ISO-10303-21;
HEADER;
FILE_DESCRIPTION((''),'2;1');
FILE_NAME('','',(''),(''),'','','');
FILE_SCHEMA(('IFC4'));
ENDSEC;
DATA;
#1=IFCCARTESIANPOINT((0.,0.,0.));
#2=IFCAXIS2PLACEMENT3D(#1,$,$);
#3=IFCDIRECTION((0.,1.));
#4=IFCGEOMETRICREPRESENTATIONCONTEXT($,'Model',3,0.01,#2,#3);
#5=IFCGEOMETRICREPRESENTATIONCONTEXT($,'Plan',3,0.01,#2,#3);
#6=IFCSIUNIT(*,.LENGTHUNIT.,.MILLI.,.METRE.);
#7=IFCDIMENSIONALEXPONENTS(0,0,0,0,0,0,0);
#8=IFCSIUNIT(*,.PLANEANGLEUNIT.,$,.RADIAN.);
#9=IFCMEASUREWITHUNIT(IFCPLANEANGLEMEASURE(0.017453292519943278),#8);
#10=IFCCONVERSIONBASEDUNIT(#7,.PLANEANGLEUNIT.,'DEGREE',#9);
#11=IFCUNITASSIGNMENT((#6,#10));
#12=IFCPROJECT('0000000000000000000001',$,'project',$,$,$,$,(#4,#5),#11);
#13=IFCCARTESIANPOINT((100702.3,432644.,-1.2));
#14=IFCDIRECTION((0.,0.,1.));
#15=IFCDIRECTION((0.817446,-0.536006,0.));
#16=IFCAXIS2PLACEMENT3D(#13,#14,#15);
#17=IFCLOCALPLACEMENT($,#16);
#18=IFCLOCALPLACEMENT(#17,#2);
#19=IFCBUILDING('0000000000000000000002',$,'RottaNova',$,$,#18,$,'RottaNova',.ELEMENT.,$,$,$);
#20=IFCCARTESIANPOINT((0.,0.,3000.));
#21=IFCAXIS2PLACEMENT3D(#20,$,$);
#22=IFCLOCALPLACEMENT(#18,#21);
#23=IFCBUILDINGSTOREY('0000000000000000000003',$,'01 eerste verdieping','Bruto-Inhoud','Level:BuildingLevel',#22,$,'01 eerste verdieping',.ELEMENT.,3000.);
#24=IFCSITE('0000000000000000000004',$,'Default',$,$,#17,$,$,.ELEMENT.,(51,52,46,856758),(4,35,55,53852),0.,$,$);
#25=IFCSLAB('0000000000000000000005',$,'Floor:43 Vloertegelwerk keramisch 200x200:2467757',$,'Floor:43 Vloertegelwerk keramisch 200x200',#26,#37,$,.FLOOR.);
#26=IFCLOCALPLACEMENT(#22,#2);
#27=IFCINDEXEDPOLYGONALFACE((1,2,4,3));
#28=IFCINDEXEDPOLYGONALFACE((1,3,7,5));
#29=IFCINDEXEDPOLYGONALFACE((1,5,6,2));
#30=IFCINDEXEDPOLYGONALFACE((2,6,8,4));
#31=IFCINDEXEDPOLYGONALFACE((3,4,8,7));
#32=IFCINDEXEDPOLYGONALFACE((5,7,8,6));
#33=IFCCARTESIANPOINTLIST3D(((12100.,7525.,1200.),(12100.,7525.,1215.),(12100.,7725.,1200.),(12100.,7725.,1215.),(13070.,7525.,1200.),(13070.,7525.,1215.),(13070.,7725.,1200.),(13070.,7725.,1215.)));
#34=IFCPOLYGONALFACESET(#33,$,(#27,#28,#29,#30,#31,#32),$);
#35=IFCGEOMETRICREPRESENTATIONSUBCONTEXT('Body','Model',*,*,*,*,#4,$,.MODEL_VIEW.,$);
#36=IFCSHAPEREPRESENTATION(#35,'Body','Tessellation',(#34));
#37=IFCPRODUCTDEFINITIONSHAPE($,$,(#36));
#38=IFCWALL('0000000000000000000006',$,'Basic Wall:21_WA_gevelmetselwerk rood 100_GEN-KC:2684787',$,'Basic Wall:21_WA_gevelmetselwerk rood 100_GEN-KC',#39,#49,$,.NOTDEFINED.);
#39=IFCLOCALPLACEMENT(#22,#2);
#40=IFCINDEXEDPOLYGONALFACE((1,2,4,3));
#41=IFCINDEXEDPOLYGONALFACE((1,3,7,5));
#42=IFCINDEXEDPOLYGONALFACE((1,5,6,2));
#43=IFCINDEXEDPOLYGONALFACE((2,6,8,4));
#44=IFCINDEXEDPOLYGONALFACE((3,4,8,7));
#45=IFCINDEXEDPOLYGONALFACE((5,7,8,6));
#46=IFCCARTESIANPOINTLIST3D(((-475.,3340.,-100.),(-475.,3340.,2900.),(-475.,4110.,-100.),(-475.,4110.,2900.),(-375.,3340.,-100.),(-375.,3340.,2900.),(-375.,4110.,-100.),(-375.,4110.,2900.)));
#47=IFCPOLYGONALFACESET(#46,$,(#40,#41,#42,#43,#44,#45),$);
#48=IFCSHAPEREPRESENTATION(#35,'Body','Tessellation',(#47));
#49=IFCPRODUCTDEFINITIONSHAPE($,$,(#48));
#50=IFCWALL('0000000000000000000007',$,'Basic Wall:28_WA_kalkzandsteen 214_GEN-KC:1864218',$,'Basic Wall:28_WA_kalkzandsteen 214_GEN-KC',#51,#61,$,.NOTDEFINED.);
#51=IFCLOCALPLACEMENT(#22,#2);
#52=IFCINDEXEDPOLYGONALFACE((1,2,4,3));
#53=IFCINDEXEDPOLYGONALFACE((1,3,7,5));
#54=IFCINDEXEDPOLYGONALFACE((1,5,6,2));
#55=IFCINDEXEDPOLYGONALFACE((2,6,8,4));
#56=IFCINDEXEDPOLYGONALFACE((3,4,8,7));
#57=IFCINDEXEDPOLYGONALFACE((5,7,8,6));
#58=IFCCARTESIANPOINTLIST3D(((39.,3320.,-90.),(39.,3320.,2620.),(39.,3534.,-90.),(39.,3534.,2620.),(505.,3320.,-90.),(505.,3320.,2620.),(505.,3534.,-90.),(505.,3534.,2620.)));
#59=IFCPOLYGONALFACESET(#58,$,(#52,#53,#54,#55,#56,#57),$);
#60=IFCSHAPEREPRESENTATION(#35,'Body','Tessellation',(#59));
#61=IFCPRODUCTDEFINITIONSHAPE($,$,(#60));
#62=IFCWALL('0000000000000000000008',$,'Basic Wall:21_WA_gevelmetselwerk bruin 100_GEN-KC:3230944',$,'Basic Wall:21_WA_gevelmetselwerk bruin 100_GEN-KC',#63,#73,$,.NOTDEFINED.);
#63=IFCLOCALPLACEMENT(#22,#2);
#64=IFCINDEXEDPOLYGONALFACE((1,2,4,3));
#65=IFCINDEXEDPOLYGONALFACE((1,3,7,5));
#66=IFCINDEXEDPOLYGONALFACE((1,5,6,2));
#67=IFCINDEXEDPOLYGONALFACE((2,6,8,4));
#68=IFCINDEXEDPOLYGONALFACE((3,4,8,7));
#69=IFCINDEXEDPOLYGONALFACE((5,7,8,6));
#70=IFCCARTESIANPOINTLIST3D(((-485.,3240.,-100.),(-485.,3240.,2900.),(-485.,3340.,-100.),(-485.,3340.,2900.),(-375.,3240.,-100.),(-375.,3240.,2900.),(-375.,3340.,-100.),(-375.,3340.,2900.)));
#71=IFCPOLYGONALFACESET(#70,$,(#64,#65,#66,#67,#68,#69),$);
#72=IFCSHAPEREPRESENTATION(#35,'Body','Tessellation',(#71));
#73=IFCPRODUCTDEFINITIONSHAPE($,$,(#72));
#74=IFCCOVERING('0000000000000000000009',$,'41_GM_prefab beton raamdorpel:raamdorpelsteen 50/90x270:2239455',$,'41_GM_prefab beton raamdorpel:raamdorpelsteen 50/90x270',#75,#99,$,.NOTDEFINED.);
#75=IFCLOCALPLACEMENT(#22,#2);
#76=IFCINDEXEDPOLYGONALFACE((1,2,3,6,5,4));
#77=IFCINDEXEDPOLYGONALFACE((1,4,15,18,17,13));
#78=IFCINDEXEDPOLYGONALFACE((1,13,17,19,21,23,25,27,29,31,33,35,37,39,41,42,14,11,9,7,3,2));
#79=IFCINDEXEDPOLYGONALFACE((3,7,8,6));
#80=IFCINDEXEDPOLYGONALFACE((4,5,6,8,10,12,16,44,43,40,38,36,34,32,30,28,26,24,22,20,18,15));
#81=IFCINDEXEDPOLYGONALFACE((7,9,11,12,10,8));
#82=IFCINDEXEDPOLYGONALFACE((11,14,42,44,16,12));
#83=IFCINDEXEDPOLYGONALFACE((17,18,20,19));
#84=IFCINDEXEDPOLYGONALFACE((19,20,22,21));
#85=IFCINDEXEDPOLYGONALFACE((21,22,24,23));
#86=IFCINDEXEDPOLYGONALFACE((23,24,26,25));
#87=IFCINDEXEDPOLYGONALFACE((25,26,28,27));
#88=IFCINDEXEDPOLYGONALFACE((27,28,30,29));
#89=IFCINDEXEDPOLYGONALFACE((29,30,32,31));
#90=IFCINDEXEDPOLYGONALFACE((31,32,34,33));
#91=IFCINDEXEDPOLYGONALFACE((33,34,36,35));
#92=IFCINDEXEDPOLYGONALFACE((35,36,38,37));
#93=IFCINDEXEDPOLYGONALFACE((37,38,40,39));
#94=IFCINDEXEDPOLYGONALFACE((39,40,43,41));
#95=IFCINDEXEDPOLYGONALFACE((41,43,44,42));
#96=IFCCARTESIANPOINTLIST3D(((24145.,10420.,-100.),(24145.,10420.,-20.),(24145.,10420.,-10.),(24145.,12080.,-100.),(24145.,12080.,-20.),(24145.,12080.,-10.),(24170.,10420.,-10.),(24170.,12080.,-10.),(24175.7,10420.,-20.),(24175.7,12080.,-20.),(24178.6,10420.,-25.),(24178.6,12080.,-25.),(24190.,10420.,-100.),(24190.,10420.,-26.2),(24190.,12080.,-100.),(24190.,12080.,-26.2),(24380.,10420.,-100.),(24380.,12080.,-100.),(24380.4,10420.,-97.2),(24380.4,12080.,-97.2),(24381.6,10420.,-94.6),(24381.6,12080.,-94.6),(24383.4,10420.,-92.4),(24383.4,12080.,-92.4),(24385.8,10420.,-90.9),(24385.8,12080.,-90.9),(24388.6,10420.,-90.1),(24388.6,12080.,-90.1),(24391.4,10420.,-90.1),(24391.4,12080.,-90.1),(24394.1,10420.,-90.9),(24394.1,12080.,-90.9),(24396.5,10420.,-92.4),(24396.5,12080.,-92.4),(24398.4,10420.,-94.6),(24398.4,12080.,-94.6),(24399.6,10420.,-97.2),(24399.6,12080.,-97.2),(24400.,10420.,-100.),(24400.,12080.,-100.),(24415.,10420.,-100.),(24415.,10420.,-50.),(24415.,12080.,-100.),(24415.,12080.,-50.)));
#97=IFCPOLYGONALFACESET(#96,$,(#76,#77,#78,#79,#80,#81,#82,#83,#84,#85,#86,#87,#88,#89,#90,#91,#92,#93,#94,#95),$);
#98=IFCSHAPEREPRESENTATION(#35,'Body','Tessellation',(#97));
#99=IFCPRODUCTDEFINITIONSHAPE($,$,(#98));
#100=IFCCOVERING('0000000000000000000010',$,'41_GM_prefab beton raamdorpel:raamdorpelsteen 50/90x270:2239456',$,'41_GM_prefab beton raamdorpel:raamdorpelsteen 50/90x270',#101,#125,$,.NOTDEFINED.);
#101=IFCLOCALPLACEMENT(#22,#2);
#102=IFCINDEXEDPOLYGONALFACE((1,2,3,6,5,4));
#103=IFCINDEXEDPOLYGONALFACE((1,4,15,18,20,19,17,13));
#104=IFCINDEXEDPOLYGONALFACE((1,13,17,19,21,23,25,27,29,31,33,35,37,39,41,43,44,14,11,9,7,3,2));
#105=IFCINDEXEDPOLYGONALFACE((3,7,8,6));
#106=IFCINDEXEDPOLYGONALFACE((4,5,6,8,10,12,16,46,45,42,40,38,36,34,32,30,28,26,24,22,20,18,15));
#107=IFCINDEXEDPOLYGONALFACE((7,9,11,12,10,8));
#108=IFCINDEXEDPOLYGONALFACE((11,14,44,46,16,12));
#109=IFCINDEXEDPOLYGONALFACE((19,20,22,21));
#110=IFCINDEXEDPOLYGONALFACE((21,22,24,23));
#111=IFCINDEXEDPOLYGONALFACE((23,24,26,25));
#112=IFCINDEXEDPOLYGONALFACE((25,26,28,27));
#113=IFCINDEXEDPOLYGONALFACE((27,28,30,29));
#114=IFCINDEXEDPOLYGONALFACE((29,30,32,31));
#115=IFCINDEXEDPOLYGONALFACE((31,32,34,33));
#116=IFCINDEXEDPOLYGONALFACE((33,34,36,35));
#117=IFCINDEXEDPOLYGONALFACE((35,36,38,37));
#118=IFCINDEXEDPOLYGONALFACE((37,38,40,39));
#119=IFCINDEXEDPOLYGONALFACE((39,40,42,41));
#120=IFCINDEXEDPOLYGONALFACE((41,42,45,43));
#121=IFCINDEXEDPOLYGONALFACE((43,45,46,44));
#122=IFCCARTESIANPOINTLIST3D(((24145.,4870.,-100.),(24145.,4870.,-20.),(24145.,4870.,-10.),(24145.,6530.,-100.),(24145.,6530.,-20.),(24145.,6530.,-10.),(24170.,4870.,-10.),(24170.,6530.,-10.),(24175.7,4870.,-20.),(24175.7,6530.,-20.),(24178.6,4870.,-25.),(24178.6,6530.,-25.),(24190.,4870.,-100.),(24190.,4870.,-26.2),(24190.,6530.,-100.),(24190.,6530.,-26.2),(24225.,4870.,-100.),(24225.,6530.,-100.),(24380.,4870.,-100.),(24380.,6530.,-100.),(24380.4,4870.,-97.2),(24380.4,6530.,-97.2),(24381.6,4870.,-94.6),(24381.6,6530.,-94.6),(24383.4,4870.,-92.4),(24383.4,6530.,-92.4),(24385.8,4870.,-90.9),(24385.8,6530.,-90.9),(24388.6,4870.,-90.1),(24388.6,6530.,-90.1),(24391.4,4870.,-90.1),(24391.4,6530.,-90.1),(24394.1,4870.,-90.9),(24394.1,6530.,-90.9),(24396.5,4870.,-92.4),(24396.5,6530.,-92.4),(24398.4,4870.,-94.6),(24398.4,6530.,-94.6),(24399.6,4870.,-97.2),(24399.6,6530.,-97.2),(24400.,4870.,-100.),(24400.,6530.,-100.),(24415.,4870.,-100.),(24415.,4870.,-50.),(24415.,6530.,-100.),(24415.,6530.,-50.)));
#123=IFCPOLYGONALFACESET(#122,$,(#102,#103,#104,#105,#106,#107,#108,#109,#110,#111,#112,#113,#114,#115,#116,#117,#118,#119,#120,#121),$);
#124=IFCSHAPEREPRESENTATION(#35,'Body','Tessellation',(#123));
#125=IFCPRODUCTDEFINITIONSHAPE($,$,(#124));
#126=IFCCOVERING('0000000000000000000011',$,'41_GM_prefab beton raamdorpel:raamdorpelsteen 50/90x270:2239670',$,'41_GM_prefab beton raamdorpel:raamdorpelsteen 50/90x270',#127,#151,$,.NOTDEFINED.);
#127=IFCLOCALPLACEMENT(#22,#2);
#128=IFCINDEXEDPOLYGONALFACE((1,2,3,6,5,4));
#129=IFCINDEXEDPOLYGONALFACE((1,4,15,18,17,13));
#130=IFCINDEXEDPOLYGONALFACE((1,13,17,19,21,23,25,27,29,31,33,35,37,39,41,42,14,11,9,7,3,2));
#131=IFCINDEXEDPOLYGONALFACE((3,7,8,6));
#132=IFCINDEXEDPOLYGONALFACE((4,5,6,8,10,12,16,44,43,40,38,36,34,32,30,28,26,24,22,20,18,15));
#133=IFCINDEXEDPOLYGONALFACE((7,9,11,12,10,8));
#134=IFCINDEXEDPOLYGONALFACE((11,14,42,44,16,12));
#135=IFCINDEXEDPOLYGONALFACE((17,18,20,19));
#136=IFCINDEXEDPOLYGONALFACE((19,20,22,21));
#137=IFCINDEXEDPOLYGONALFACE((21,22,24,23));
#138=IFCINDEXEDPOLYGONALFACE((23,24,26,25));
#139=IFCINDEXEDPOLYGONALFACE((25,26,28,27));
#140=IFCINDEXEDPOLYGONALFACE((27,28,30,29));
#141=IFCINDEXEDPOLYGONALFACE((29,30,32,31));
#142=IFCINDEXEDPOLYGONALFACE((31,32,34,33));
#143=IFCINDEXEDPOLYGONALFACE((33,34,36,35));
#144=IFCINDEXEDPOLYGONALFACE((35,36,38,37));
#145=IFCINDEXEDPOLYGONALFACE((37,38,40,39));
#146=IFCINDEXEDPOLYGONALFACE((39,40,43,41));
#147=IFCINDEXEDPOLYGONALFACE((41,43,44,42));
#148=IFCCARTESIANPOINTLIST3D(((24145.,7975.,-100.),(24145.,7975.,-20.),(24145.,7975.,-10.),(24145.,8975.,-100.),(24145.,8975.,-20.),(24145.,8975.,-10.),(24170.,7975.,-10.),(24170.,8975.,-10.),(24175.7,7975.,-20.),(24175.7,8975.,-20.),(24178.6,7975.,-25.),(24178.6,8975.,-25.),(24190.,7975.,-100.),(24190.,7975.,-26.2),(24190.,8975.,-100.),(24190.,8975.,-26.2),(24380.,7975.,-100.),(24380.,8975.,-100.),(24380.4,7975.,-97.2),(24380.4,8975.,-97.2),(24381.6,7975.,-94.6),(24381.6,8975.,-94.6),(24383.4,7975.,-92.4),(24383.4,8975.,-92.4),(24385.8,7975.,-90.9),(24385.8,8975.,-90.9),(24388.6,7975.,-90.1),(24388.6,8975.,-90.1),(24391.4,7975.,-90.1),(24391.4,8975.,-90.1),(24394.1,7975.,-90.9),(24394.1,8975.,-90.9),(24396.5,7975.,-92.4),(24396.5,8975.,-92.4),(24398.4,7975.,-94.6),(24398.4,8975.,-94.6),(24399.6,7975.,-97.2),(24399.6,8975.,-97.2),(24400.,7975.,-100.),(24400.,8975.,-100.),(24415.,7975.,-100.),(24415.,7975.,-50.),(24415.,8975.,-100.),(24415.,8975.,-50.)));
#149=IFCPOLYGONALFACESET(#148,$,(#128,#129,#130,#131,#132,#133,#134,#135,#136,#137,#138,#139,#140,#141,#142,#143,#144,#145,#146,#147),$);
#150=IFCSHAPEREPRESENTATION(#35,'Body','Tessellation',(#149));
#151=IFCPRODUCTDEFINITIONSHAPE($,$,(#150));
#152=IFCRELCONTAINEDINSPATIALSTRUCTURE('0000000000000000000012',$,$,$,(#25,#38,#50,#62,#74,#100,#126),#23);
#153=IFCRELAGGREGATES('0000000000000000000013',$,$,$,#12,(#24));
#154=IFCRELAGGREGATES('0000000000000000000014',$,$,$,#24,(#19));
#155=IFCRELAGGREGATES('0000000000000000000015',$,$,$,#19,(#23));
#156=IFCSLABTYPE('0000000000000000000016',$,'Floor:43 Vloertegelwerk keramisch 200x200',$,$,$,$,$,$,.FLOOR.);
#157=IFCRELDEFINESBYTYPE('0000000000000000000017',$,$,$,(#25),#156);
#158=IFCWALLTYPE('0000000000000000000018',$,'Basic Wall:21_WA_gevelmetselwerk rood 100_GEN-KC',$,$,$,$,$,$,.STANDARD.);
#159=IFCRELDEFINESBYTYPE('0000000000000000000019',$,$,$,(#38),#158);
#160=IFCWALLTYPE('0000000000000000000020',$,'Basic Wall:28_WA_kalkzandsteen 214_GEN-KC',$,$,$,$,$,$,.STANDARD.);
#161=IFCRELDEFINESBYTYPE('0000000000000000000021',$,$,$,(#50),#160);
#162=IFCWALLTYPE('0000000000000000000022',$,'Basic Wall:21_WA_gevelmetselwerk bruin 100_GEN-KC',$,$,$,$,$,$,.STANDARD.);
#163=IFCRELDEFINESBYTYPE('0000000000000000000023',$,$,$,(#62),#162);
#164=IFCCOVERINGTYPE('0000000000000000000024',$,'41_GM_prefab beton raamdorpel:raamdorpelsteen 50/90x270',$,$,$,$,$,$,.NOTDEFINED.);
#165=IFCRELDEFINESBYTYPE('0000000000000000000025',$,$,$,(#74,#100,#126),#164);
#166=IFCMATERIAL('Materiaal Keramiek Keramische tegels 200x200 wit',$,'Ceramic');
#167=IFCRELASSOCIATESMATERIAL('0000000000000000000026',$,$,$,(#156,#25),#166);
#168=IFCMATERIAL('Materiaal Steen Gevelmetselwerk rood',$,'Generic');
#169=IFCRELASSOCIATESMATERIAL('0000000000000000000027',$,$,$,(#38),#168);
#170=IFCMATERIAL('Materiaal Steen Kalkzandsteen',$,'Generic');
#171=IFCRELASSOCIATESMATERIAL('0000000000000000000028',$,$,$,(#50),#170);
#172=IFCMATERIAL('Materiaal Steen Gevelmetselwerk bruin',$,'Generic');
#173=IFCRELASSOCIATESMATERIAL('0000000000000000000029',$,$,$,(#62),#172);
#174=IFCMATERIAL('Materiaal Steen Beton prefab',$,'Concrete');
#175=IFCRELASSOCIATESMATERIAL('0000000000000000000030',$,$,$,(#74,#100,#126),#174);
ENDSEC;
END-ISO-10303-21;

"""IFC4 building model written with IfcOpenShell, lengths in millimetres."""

from ifc_helpers import new_model, entity, si_unit, converted_unit, direction, frame, origin, place, context, subcontext, project, spatial, line, arc, indexed_curve, outline, extrude, material, type_object, element, save


model = new_model("IFC4")

# Units and contexts
model_context = context("Model", 3, precision=0.01, world=origin(), true_north=direction((0.0, 1.0)))
plan_context = context("Plan", 3, precision=0.01, world=origin(), true_north=direction((0.0, 1.0)))
body_context = subcontext(model_context, "Body", "Model", "MODEL_VIEW")
ifc_project = project(units=[si_unit("LENGTHUNIT", "METRE", prefix="MILLI"), converted_unit("PLANEANGLEUNIT", "DEGREE", entity("IfcPlaneAngleMeasure", 0.017453292519943278), si_unit("PLANEANGLEUNIT", "RADIAN"), dimensions=[0, 0, 0, 0, 0, 0, 0])], contexts=[model_context, plan_context])

# Site, building, storey
site_placement = place(None, frame((100702.3, 432644.0, -1.2), z_axis=(0.0, 0.0, 1.0), x_axis=(0.817446, -0.536006, 0.0)))
site = spatial("IfcSite", under=ifc_project, at=site_placement, Name="Default", CompositionType="ELEMENT", RefLatitude=(51, 52, 46, 856758), RefLongitude=(4, 35, 55, 53852), RefElevation=0.0)
building_placement = place(site_placement, origin())
building = spatial("IfcBuilding", under=site, at=building_placement, Name="RottaNova", LongName="RottaNova", CompositionType="ELEMENT")
storey_placement = place(building_placement, frame((0.0, 0.0, 3000.0)))
storey = spatial("IfcBuildingStorey", under=building, at=storey_placement, Name="01 eerste verdieping", Description="Bruto-Inhoud", ObjectType="Level:BuildingLevel", LongName="01 eerste verdieping", CompositionType="ELEMENT", Elevation=3000.0)

# Shared definitions
ifc_material_1 = material(Name="Materiaal Steen Beton prefab", Category="Concrete")

# Slab
ifc_material_2 = material(Name="Materiaal Keramiek Keramische tegels 200x200 wit", Category="Ceramic")
slab_type = type_object("IfcSlabType", Name="Floor:43 Vloertegelwerk keramisch 200x200", PredefinedType="FLOOR", material=ifc_material_2)
slab_placement = place(storey_placement, origin())
element("IfcSlab", 1, at=slab_placement, inside=storey, type_object=slab_type, material=ifc_material_2, Name="Floor:43 Vloertegelwerk keramisch 200x200:2467757", ObjectType="Floor:43 Vloertegelwerk keramisch 200x200", PredefinedType="FLOOR", context=body_context, shape_type="SweptSolid", body=[
    extrude(outline(indexed_curve([(-100.0, -485.0), (100.0, -485.0), (100.0, 485.0), (-100.0, 485.0), (-100.0, -485.0)], self_intersect=False)), frame((12585.0, 7625.0, 1215.0), z_axis=(0.0, 0.0, -1.0), x_axis=(0.0, 1.0, 0.0)), (0.0, 0.0, 1.0), 15.0),
])

# Walls
ifc_material_3 = material(Name="Materiaal Steen Gevelmetselwerk rood", Category="Generic")
wall_type_1 = type_object("IfcWallType", Name="Basic Wall:21_WA_gevelmetselwerk rood 100_GEN-KC", PredefinedType="STANDARD")
wall_1_placement = place(storey_placement, frame((-425.0, 3340.0, -100.0), z_axis=(0.0, 0.0, 1.0), x_axis=(0.0, 1.0, 0.0)))
element("IfcWall", 2, at=wall_1_placement, inside=storey, type_object=wall_type_1, material=ifc_material_3, Name="Basic Wall:21_WA_gevelmetselwerk rood 100_GEN-KC:2684787", ObjectType="Basic Wall:21_WA_gevelmetselwerk rood 100_GEN-KC", PredefinedType="NOTDEFINED", context=body_context, shape_type="SweptSolid", body=[
    extrude(outline(indexed_curve([(770.0, 50.0), (0.0, 50.0), (0.0, -50.0), (770.0, -50.0), (770.0, 50.0)], self_intersect=False)), origin(), (0.0, 0.0, 1.0), 3000.0),
])
ifc_material_4 = material(Name="Materiaal Steen Kalkzandsteen", Category="Generic")
wall_type_2 = type_object("IfcWallType", Name="Basic Wall:28_WA_kalkzandsteen 214_GEN-KC", PredefinedType="STANDARD")
wall_2_placement = place(storey_placement, frame((39.0, 3427.0, -90.0)))
element("IfcWall", 3, at=wall_2_placement, inside=storey, type_object=wall_type_2, material=ifc_material_4, Name="Basic Wall:28_WA_kalkzandsteen 214_GEN-KC:1864218", ObjectType="Basic Wall:28_WA_kalkzandsteen 214_GEN-KC", PredefinedType="NOTDEFINED", context=body_context, shape_type="SweptSolid", body=[
    extrude(outline(indexed_curve([(466.0, 107.0), (0.0, 107.0), (0.0, -107.0), (466.0, -107.0), (466.0, 107.0)], self_intersect=False)), origin(), (0.0, 0.0, 1.0), 2710.0),
])
ifc_material_5 = material(Name="Materiaal Steen Gevelmetselwerk bruin", Category="Generic")
wall_type_3 = type_object("IfcWallType", Name="Basic Wall:21_WA_gevelmetselwerk bruin 100_GEN-KC", PredefinedType="STANDARD")
wall_3_placement = place(storey_placement, frame((-485.0, 3290.0, -100.0)))
element("IfcWall", 4, at=wall_3_placement, inside=storey, type_object=wall_type_3, material=ifc_material_5, Name="Basic Wall:21_WA_gevelmetselwerk bruin 100_GEN-KC:3230944", ObjectType="Basic Wall:21_WA_gevelmetselwerk bruin 100_GEN-KC", PredefinedType="NOTDEFINED", context=body_context, shape_type="SweptSolid", body=[
    extrude(outline(indexed_curve([(110.0, 50.0), (0.0, 50.0), (0.0, -50.0), (110.0, -50.0), (110.0, 50.0)], self_intersect=False)), origin(), (0.0, 0.0, 1.0), 3000.0),
])

# Coverings
covering_type_1 = type_object("IfcCoveringType", Name="41_GM_prefab beton raamdorpel:raamdorpelsteen 50/90x270", PredefinedType="NOTDEFINED")
covering_1_placement = place(storey_placement, origin())
element("IfcCovering", 5, at=covering_1_placement, inside=storey, type_object=covering_type_1, material=ifc_material_1, Name="41_GM_prefab beton raamdorpel:raamdorpelsteen 50/90x270:2239455", ObjectType="41_GM_prefab beton raamdorpel:raamdorpelsteen 50/90x270", PredefinedType="NOTDEFINED", context=body_context, shape_type="SweptSolid", body=[
    extrude(outline(indexed_curve([(-77.0, -43.1), (-89.5, -64.7), (-80.8, -69.7), (-11.5, -109.7), (11.0, -70.7), (106.0, 93.8), (102.3, 107.5), (116.0, 111.1), (123.5, 124.1), (80.2, 149.1), (-52.9, -33.8), (-59.6, -43.1), (-65.4, -43.1)], segments=[line(1, 2, 3, 4, 5, 6), arc(6, 7, 8), line(8, 9, 10, 11, 12, 13, 1)], self_intersect=False)), frame((24245.8, 10420.0, -55.1), z_axis=(0.0, -1.0, 0.0), x_axis=(0.5, 0.0, -0.866025)), (0.0, 0.0, -1.0), 1660.0),
])
covering_2_placement = place(storey_placement, origin())
element("IfcCovering", 6, at=covering_2_placement, inside=storey, type_object=covering_type_1, material=ifc_material_1, Name="41_GM_prefab beton raamdorpel:raamdorpelsteen 50/90x270:2239456", ObjectType="41_GM_prefab beton raamdorpel:raamdorpelsteen 50/90x270", PredefinedType="NOTDEFINED", context=body_context, shape_type="SweptSolid", body=[
    extrude(outline(indexed_curve([(-79.1, -40.0), (-91.6, -61.6), (-83.0, -66.6), (-13.7, -106.6), (8.8, -67.6), (26.3, -37.3), (103.8, 96.9), (100.1, 110.6), (113.8, 114.2), (121.3, 127.2), (78.0, 152.2), (-55.1, -30.7), (-61.8, -40.0), (-67.6, -40.0)], segments=[line(1, 2, 3, 4, 5, 6, 7), arc(7, 8, 9), line(9, 10, 11, 12, 13, 14, 1)], self_intersect=False)), frame((24244.2, 4870.0, -58.6), z_axis=(0.0, -1.0, 0.0), x_axis=(0.5, 0.0, -0.866025)), (0.0, 0.0, -1.0), 1660.0),
])
covering_3_placement = place(storey_placement, origin())
element("IfcCovering", 7, at=covering_3_placement, inside=storey, type_object=covering_type_1, material=ifc_material_1, Name="41_GM_prefab beton raamdorpel:raamdorpelsteen 50/90x270:2239670", ObjectType="41_GM_prefab beton raamdorpel:raamdorpelsteen 50/90x270", PredefinedType="NOTDEFINED", context=body_context, shape_type="SweptSolid", body=[
    extrude(outline(indexed_curve([(-77.0, -43.1), (-89.5, -64.7), (-80.8, -69.7), (-11.5, -109.7), (11.0, -70.7), (106.0, 93.8), (102.3, 107.5), (116.0, 111.1), (123.5, 124.1), (80.2, 149.1), (-52.9, -33.8), (-59.6, -43.1), (-65.4, -43.1)], segments=[line(1, 2, 3, 4, 5, 6), arc(6, 7, 8), line(8, 9, 10, 11, 12, 13, 1)], self_intersect=False)), frame((24245.8, 7975.0, -55.1), z_axis=(0.0, -1.0, 0.0), x_axis=(0.5, 0.0, -0.866025)), (0.0, 0.0, -1.0), 1000.0),
])

save(model, "model.ifc")
